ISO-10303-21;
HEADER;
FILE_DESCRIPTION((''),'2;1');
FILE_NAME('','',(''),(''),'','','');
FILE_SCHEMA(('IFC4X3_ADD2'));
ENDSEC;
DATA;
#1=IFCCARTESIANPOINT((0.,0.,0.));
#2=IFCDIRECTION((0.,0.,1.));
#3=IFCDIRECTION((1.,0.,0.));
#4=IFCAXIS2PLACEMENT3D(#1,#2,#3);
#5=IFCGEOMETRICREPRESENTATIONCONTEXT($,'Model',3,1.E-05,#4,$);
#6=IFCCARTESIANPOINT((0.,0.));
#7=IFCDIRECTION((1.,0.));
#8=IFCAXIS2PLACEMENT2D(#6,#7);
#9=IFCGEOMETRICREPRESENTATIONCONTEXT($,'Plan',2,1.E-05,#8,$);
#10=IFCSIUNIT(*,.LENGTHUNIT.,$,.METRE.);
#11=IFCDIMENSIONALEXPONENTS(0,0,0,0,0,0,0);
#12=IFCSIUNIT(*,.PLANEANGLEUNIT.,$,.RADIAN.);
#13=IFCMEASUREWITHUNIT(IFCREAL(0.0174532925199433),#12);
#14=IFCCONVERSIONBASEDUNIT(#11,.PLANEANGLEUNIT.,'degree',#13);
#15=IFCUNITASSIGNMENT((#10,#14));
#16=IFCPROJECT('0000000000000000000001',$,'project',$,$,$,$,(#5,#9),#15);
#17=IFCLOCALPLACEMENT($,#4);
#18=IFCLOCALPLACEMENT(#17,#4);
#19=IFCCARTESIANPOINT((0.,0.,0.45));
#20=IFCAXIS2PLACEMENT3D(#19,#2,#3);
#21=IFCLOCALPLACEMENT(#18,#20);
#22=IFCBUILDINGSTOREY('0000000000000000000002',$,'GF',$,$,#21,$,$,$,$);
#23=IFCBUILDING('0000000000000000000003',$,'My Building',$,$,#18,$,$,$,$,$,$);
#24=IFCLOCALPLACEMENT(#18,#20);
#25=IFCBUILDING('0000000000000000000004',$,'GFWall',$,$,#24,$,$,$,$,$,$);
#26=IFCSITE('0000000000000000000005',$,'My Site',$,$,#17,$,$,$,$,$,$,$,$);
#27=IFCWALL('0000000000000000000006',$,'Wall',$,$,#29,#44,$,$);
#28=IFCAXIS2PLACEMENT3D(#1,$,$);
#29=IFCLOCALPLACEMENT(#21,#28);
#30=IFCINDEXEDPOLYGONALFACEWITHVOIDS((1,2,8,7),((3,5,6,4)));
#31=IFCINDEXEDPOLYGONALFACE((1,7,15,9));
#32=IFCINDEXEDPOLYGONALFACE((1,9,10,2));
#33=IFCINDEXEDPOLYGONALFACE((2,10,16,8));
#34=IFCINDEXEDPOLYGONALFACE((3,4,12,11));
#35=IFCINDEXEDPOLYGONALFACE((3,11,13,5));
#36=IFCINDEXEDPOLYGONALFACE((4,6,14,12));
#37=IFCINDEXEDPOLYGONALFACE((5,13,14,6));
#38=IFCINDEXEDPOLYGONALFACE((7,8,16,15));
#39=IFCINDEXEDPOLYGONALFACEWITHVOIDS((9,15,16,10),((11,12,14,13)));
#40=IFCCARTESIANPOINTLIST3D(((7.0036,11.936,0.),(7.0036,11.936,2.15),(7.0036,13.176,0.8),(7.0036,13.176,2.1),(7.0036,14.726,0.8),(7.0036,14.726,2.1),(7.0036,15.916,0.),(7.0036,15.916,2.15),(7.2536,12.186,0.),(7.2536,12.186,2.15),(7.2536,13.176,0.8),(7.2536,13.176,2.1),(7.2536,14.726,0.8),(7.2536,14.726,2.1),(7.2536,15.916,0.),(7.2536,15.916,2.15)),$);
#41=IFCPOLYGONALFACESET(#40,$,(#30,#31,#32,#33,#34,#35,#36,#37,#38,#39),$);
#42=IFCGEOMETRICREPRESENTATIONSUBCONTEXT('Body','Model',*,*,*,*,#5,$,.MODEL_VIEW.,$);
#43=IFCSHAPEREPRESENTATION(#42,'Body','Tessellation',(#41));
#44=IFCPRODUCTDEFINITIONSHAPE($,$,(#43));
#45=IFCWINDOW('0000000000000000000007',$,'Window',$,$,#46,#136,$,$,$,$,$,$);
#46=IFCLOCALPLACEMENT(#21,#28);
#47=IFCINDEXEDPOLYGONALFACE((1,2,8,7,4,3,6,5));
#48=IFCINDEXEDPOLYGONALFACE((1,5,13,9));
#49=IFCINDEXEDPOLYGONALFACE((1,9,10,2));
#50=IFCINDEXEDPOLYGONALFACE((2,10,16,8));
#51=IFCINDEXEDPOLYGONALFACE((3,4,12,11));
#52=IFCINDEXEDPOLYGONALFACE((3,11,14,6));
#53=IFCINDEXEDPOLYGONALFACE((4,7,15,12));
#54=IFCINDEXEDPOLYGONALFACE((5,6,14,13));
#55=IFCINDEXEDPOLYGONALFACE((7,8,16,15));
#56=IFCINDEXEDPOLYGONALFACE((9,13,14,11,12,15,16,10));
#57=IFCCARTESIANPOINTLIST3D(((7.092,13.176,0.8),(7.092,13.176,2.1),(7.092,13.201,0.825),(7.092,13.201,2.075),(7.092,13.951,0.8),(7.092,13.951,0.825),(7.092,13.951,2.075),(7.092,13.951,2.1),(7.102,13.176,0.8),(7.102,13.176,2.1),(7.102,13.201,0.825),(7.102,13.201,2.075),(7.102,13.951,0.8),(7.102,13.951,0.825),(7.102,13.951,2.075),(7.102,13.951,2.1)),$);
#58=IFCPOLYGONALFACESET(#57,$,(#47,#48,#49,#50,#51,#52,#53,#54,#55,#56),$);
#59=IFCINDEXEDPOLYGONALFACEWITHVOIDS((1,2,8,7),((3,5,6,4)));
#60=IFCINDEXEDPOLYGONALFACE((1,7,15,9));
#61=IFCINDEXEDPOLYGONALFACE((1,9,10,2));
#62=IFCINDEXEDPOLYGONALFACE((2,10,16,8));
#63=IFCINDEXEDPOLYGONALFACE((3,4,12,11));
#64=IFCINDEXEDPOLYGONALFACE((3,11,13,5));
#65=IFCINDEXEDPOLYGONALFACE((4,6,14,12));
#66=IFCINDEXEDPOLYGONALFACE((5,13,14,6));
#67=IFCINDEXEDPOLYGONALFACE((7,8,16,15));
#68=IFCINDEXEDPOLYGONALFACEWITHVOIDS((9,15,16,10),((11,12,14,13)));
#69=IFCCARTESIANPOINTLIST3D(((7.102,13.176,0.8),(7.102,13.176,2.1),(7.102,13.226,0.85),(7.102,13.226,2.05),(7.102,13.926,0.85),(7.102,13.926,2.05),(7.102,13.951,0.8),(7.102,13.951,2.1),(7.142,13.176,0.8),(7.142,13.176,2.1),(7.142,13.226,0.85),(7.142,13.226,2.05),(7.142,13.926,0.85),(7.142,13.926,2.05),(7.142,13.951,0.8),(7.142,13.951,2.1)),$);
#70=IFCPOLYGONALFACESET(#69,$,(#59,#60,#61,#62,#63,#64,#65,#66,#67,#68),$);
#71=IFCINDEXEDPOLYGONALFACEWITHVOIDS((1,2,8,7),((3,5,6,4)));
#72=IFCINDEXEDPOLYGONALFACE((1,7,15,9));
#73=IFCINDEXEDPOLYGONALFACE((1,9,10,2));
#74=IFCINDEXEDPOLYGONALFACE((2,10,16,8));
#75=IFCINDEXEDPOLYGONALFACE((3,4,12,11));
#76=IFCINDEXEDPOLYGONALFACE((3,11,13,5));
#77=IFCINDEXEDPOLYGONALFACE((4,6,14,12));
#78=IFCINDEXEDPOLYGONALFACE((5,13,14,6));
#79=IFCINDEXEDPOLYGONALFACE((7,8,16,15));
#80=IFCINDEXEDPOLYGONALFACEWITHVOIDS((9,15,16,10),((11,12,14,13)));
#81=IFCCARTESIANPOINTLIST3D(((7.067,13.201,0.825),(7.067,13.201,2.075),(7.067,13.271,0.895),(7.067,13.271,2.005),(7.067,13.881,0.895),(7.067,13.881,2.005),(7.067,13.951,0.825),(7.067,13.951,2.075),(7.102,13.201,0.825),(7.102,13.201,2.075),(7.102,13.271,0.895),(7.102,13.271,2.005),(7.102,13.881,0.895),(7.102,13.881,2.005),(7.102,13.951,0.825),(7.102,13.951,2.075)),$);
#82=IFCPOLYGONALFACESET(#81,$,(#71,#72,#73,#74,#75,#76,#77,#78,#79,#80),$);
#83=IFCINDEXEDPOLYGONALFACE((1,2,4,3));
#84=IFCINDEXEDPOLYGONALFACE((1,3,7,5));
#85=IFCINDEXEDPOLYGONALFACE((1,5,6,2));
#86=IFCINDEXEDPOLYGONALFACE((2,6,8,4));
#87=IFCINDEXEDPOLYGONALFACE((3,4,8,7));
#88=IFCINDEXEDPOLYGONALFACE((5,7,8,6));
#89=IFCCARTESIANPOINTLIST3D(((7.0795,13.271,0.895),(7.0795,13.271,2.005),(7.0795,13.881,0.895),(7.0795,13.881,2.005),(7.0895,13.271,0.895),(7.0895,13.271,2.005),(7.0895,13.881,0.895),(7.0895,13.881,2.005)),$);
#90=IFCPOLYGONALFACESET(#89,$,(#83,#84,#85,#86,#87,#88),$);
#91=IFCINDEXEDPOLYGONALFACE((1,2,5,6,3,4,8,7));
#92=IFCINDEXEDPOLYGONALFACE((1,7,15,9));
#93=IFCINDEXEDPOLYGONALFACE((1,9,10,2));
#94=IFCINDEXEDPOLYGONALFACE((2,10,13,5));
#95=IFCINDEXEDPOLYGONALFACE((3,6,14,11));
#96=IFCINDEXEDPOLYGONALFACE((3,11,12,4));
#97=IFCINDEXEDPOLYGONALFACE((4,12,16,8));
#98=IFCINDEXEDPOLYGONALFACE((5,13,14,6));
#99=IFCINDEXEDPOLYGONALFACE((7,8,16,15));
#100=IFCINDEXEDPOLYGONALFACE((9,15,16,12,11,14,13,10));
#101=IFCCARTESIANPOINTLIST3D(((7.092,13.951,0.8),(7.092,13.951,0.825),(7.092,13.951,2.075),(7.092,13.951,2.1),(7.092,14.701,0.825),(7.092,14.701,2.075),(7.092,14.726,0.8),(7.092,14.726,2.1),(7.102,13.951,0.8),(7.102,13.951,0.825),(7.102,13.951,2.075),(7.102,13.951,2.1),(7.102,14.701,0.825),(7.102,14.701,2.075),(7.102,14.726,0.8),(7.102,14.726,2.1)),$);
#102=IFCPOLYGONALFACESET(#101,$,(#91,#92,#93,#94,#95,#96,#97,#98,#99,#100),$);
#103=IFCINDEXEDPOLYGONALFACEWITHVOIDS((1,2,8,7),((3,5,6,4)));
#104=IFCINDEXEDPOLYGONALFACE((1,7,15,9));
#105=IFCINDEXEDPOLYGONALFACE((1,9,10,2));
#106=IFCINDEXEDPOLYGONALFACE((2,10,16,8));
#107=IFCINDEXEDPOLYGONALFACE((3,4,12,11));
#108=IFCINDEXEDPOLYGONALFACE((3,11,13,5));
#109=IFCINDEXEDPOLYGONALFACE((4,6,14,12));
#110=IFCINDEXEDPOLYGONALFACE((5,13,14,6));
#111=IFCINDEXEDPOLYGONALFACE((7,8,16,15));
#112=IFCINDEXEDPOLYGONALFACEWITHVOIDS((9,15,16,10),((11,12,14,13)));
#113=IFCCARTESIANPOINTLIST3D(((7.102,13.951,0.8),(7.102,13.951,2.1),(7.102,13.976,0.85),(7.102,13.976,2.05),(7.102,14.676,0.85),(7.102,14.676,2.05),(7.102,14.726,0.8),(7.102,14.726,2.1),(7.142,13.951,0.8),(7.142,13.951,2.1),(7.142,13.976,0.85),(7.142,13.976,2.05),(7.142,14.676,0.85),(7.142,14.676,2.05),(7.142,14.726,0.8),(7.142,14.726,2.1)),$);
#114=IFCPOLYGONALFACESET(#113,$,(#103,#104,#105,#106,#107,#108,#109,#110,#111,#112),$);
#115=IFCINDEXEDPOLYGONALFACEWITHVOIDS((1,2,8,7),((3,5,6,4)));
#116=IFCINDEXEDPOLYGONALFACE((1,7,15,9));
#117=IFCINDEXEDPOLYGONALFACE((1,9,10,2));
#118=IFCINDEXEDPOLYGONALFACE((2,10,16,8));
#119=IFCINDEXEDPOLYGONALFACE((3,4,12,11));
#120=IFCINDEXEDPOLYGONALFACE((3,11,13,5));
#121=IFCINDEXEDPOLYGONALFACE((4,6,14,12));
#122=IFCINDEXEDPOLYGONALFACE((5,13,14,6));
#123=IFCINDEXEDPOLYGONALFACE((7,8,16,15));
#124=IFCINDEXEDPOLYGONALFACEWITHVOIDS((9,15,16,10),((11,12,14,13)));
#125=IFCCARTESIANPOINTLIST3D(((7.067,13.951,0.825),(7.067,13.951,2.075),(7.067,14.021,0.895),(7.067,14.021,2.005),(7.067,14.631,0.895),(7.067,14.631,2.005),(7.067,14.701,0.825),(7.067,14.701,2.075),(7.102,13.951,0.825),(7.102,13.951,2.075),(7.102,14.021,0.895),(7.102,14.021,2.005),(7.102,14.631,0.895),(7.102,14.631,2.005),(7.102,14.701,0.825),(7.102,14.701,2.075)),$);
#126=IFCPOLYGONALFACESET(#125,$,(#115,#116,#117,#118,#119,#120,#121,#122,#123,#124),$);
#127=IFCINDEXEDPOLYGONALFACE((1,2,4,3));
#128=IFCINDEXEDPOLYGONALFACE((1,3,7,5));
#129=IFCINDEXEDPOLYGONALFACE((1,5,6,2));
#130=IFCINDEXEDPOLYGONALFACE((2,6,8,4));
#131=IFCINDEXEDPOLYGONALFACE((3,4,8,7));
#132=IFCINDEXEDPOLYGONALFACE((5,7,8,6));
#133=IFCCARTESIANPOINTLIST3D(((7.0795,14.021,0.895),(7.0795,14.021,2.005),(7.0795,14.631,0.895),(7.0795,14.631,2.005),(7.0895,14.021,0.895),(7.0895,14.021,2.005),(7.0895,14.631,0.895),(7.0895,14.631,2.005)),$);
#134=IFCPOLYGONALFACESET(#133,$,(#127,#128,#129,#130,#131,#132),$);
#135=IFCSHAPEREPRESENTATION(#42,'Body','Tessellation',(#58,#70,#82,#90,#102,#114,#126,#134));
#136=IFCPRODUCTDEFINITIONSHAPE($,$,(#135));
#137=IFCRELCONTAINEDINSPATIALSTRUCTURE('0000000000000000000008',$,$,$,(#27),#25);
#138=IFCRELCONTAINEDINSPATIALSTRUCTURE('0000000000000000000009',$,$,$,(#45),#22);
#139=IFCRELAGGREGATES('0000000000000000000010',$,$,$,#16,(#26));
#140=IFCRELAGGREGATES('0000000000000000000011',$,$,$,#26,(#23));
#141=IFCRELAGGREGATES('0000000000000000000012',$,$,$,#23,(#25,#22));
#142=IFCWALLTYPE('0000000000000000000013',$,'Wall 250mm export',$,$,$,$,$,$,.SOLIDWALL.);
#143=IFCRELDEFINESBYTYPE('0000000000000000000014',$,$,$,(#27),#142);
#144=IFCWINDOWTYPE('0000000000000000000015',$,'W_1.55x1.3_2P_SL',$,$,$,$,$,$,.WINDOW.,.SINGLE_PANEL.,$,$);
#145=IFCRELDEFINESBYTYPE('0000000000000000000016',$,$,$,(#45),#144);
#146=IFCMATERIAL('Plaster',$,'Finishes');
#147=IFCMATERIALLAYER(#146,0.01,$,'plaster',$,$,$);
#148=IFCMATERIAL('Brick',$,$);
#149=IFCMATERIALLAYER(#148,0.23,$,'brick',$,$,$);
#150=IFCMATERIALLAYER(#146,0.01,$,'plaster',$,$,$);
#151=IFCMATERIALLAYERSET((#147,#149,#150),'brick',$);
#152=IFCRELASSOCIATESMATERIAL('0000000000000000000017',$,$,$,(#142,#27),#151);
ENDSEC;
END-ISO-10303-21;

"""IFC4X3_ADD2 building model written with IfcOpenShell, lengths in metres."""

from ifc_helpers import new_model, entity, si_unit, converted_unit, frame, origin_with_axes, origin_2d_with_axis, place, context, subcontext, project, spatial, line, indexed_curve, outline, extrude, shape, source, transform, mapped, material, layer, layer_set, layer_usage, type_object, type_shapes, element, fill, save


model = new_model("IFC4X3_ADD2")

# Units and contexts
model_context = context("Model", 3, precision=1e-05, world=origin_with_axes())
plan_context = context("Plan", 2, precision=1e-05, world=origin_2d_with_axis())
body_context_1 = subcontext(model_context, "Body", "Model", "MODEL_VIEW")
body_context_2 = subcontext(plan_context, "Body", "Plan", "PLAN_VIEW")
ifc_project = project(units=[si_unit("LENGTHUNIT", "METRE"), converted_unit("PLANEANGLEUNIT", "degree", entity("IfcReal", 0.0174532925199433), si_unit("PLANEANGLEUNIT", "RADIAN"), dimensions=[0, 0, 0, 0, 0, 0, 0])], contexts=[model_context, plan_context])

# Site, buildings
site_placement = place(None, origin_with_axes())
site = spatial("IfcSite", under=ifc_project, at=site_placement, Name="My Site")
building_1_placement = place(site_placement, origin_with_axes())
building_1 = spatial("IfcBuilding", under=site, at=building_1_placement, Name="My Building")
building_2_placement = place(building_1_placement, frame((0.0, 0.0, 0.45), z_axis=(0.0, 0.0, 1.0), x_axis=(1.0, 0.0, 0.0)))
building_2 = spatial("IfcBuilding", under=building_1, at=building_2_placement, Name="GFWall")

# Shared definitions
ifc_material_1 = material(Name="Plaster", Category="Finishes")
ifc_layer_1 = layer(ifc_material_1, 0.01, Name="plaster")
ifc_material_2 = material(Name="Brick")
ifc_layer_2 = layer(ifc_material_2, 0.23, Name="brick")
ifc_layer_3 = layer(ifc_material_1, 0.01, Name="plaster")
ifc_layer_set = layer_set([ifc_layer_1, ifc_layer_2, ifc_layer_3], Name="brick")
wall_type = type_object("IfcWallType", Name="Wall 250mm export", PredefinedType="SOLIDWALL", material=ifc_layer_set)

# Shared definitions
storey_placement = place(building_1_placement, frame((0.0, 0.0, 0.45), z_axis=(0.0, 0.0, 1.0), x_axis=(1.0, 0.0, 0.0)))
storey = spatial("IfcBuildingStorey", under=building_1, at=storey_placement, Name="GF")

# Wall, opening, window
ifc_layer_usage_1 = layer_usage(ifc_layer_set, "AXIS2", "POSITIVE", 0.0)
wall_1_placement = place(building_2_placement, frame((7.2536, 11.936, 0.0), z_axis=(0.0, 0.0, 1.0), x_axis=(0.0, 1.0, 0.0)))
wall_1 = element("IfcWall", 1, at=wall_1_placement, inside=building_2, type_object=wall_type, material=ifc_layer_usage_1, Name="Wall", context=body_context_1, shape_type="SweptSolid", body=[
    extrude(outline(indexed_curve([(0.25, 0.0), (0.0, 0.25), (3.98, 0.25), (3.98, 0.0)], segments=[line(1, 2, 3, 4, 1)])), origin_with_axes(), (0.0, 0.0, 1.0), 2.15),
])
shared_shape_1 = source(origin_with_axes(), body_context_1, "Body", "SweptSolid", [
    extrude(outline(indexed_curve([(0.0, 0.0), (1.55, 0.0), (1.55, 1.3), (0.0, 1.3)], segments=[line(1, 2, 3, 4, 1)])), frame((0.0, -0.6, 0.0), z_axis=(0.0, -1.0, 0.0), x_axis=(1.0, 0.0, 0.0)), (0.0, 0.0, -1.0), 1.2),
])
opening_1_placement = place(wall_1_placement, frame((1.24, 0.0616, 0.8), z_axis=(0.0, 0.0, 1.0), x_axis=(1.0, 0.0, 0.0)))
opening_1 = element("IfcOpeningElement", 2, at=opening_1_placement, cuts=wall_1, PredefinedType="OPENING", context=body_context_1, shape_type="MappedRepresentation", body=[
    mapped(shared_shape_1, transform((0.0, 0.0, 0.0), x_axis=(1.0, 0.0, 0.0), y_axis=(0.0, 1.0, 0.0), z_axis=(0.0, 0.0, 1.0), scale=1.0)),
])
window_type_1 = type_object("IfcWindowType", Name="W_1.55x1.3_2P_SL", PartitioningType="SINGLE_PANEL", PredefinedType="WINDOW")
shared_shape_2 = source(origin_with_axes(), body_context_1, "Body", "SweptSolid", [
    extrude(outline(indexed_curve([(0.775, 0.0), (0.0, 0.0), (0.0, 1.3), (0.775, 1.3), (0.775, 1.275), (0.025, 1.275), (0.025, 0.025), (0.775, 0.025)], segments=[line(1, 2, 3, 4, 5, 6, 7, 8, 1)])), frame((0.0, 0.09, 0.0), z_axis=(0.0, -1.0, 0.0), x_axis=(1.0, 0.0, 0.0)), (0.0, 0.0, -1.0), 0.01),
    extrude(outline(indexed_curve([(0.0, 0.0), (0.775, 0.0), (0.775, 1.3), (0.0, 1.3)], segments=[line(1, 2, 3, 4, 1)]), holes=[indexed_curve([(0.05, 0.05), (0.75, 0.05), (0.75, 1.25), (0.05, 1.25)], segments=[line(1, 2, 3, 4, 1)])]), frame((0.0, 0.05, 0.0), z_axis=(0.0, -1.0, 0.0), x_axis=(1.0, 0.0, 0.0)), (0.0, 0.0, -1.0), 0.04),
    extrude(outline(indexed_curve([(0.0, 0.0), (0.75, 0.0), (0.75, 1.25), (0.0, 1.25)], segments=[line(1, 2, 3, 4, 1)]), holes=[indexed_curve([(0.07, 0.07), (0.68, 0.07), (0.68, 1.18), (0.07, 1.18)], segments=[line(1, 2, 3, 4, 1)])]), frame((0.025, 0.09, 0.025), z_axis=(0.0, -1.0, 0.0), x_axis=(1.0, 0.0, 0.0)), (0.0, 0.0, -1.0), 0.035),
    extrude(outline(indexed_curve([(0.07, 0.07), (0.68, 0.07), (0.68, 1.18), (0.07, 1.18)], segments=[line(1, 2, 3, 4, 1)])), frame((0.025, 0.1025, 0.025), z_axis=(0.0, -1.0, 0.0), x_axis=(1.0, 0.0, 0.0)), (0.0, 0.0, -1.0), 0.01),
    extrude(outline(indexed_curve([(0.0, 1.3), (0.775, 1.3), (0.775, 0.0), (0.0, 0.0), (0.0, 0.025), (0.75, 0.025), (0.75, 1.275), (0.0, 1.275)], segments=[line(1, 2, 3, 4, 5, 6, 7, 8, 1)])), frame((0.775, 0.09, 0.0), z_axis=(0.0, -1.0, 0.0), x_axis=(1.0, 0.0, 0.0)), (0.0, 0.0, -1.0), 0.01),
    extrude(outline(indexed_curve([(0.0, 0.0), (0.775, 0.0), (0.775, 1.3), (0.0, 1.3)], segments=[line(1, 2, 3, 4, 1)]), holes=[indexed_curve([(0.025, 0.05), (0.725, 0.05), (0.725, 1.25), (0.025, 1.25)], segments=[line(1, 2, 3, 4, 1)])]), frame((0.775, 0.05, 0.0), z_axis=(0.0, -1.0, 0.0), x_axis=(1.0, 0.0, 0.0)), (0.0, 0.0, -1.0), 0.04),
    extrude(outline(indexed_curve([(0.0, 0.0), (0.75, 0.0), (0.75, 1.25), (0.0, 1.25)], segments=[line(1, 2, 3, 4, 1)]), holes=[indexed_curve([(0.07, 0.07), (0.68, 0.07), (0.68, 1.18), (0.07, 1.18)], segments=[line(1, 2, 3, 4, 1)])]), frame((0.775, 0.09, 0.025), z_axis=(0.0, -1.0, 0.0), x_axis=(1.0, 0.0, 0.0)), (0.0, 0.0, -1.0), 0.035),
    extrude(outline(indexed_curve([(0.07, 0.07), (0.68, 0.07), (0.68, 1.18), (0.07, 1.18)], segments=[line(1, 2, 3, 4, 1)])), frame((0.775, 0.1025, 0.025), z_axis=(0.0, -1.0, 0.0), x_axis=(1.0, 0.0, 0.0)), (0.0, 0.0, -1.0), 0.01),
])
shared_shape_3 = source(origin_with_axes(), body_context_2, "Body", "Curve2D", [
    entity("IfcIndexedPolyCurve", entity("IfcCartesianPointList2D", [[0.05, 0.05], [0.75, 0.05]])),
    entity("IfcIndexedPolyCurve", entity("IfcCartesianPointList2D", [[0.0, 0.1], [0.025, 0.1], [0.025, 0.09], [0.05, 0.09], [0.05, 0.05], [0.0, 0.05]]), [entity("IfcLineIndex", [1, 2, 3, 4, 5, 6, 1])]),
    entity("IfcIndexedPolyCurve", entity("IfcCartesianPointList2D", [[0.775, 0.1], [0.775, 0.1], [0.775, 0.09], [0.75, 0.09], [0.75, 0.05], [0.775, 0.05]])),
    entity("IfcIndexedPolyCurve", entity("IfcCartesianPointList2D", [[0.025, 0.09], [0.095, 0.09], [0.095, 0.125], [0.025, 0.125]]), [entity("IfcLineIndex", [1, 2, 3, 4, 1])]),
    entity("IfcIndexedPolyCurve", entity("IfcCartesianPointList2D", [[0.775, 0.09], [0.705, 0.09], [0.705, 0.125], [0.775, 0.125]]), [entity("IfcLineIndex", [1, 2, 3, 4, 1])]),
    entity("IfcIndexedPolyCurve", entity("IfcCartesianPointList2D", [[0.095, 0.09], [0.705, 0.09]])),
    entity("IfcIndexedPolyCurve", entity("IfcCartesianPointList2D", [[0.095, 0.125], [0.705, 0.125]])),
    entity("IfcIndexedPolyCurve", entity("IfcCartesianPointList2D", [[0.095, 0.1075], [0.705, 0.1075]])),
    entity("IfcIndexedPolyCurve", entity("IfcCartesianPointList2D", [[0.8, 0.05], [1.5, 0.05]])),
    entity("IfcIndexedPolyCurve", entity("IfcCartesianPointList2D", [[0.775, 0.1], [0.775, 0.1], [0.775, 0.09], [0.8, 0.09], [0.8, 0.05], [0.775, 0.05]])),
    entity("IfcIndexedPolyCurve", entity("IfcCartesianPointList2D", [[1.55, 0.1], [1.525, 0.1], [1.525, 0.09], [1.5, 0.09], [1.5, 0.05], [1.55, 0.05]]), [entity("IfcLineIndex", [1, 2, 3, 4, 5, 6, 1])]),
    entity("IfcIndexedPolyCurve", entity("IfcCartesianPointList2D", [[0.775, 0.09], [0.845, 0.09], [0.845, 0.125], [0.775, 0.125]]), [entity("IfcLineIndex", [1, 2, 3, 4, 1])]),
    entity("IfcIndexedPolyCurve", entity("IfcCartesianPointList2D", [[1.525, 0.09], [1.455, 0.09], [1.455, 0.125], [1.525, 0.125]]), [entity("IfcLineIndex", [1, 2, 3, 4, 1])]),
    entity("IfcIndexedPolyCurve", entity("IfcCartesianPointList2D", [[0.845, 0.09], [1.455, 0.09]])),
    entity("IfcIndexedPolyCurve", entity("IfcCartesianPointList2D", [[0.845, 0.125], [1.455, 0.125]])),
    entity("IfcIndexedPolyCurve", entity("IfcCartesianPointList2D", [[0.845, 0.1075], [1.455, 0.1075]])),
])
type_shapes(window_type_1, [shared_shape_2, shared_shape_3])
window_1_placement = place(opening_1_placement, frame((0.0, 0.0, 0.0), z_axis=(0.0, 0.0, 1.0), x_axis=(1.0, 0.0, 0.0)))
window_1 = element("IfcWindow", 3, at=window_1_placement, inside=storey, type_object=window_type_1, Name="Window", shapes=[
    shape(body_context_1, "Body", "MappedRepresentation", [mapped(shared_shape_2, transform((0.0, 0.0, 0.0), x_axis=(1.0, 0.0, 0.0), y_axis=(0.0, 1.0, 0.0), z_axis=(0.0, 0.0, 1.0), scale=1.0))]),
    shape(body_context_2, "Body", "MappedRepresentation", [mapped(shared_shape_3, transform((0.0, 0.0, 0.0), x_axis=(1.0, 0.0, 0.0), y_axis=(0.0, 1.0, 0.0), z_axis=(0.0, 0.0, 1.0), scale=1.0))]),
])
fill(opening_1, window_1)

save(model, "model.ifc")
